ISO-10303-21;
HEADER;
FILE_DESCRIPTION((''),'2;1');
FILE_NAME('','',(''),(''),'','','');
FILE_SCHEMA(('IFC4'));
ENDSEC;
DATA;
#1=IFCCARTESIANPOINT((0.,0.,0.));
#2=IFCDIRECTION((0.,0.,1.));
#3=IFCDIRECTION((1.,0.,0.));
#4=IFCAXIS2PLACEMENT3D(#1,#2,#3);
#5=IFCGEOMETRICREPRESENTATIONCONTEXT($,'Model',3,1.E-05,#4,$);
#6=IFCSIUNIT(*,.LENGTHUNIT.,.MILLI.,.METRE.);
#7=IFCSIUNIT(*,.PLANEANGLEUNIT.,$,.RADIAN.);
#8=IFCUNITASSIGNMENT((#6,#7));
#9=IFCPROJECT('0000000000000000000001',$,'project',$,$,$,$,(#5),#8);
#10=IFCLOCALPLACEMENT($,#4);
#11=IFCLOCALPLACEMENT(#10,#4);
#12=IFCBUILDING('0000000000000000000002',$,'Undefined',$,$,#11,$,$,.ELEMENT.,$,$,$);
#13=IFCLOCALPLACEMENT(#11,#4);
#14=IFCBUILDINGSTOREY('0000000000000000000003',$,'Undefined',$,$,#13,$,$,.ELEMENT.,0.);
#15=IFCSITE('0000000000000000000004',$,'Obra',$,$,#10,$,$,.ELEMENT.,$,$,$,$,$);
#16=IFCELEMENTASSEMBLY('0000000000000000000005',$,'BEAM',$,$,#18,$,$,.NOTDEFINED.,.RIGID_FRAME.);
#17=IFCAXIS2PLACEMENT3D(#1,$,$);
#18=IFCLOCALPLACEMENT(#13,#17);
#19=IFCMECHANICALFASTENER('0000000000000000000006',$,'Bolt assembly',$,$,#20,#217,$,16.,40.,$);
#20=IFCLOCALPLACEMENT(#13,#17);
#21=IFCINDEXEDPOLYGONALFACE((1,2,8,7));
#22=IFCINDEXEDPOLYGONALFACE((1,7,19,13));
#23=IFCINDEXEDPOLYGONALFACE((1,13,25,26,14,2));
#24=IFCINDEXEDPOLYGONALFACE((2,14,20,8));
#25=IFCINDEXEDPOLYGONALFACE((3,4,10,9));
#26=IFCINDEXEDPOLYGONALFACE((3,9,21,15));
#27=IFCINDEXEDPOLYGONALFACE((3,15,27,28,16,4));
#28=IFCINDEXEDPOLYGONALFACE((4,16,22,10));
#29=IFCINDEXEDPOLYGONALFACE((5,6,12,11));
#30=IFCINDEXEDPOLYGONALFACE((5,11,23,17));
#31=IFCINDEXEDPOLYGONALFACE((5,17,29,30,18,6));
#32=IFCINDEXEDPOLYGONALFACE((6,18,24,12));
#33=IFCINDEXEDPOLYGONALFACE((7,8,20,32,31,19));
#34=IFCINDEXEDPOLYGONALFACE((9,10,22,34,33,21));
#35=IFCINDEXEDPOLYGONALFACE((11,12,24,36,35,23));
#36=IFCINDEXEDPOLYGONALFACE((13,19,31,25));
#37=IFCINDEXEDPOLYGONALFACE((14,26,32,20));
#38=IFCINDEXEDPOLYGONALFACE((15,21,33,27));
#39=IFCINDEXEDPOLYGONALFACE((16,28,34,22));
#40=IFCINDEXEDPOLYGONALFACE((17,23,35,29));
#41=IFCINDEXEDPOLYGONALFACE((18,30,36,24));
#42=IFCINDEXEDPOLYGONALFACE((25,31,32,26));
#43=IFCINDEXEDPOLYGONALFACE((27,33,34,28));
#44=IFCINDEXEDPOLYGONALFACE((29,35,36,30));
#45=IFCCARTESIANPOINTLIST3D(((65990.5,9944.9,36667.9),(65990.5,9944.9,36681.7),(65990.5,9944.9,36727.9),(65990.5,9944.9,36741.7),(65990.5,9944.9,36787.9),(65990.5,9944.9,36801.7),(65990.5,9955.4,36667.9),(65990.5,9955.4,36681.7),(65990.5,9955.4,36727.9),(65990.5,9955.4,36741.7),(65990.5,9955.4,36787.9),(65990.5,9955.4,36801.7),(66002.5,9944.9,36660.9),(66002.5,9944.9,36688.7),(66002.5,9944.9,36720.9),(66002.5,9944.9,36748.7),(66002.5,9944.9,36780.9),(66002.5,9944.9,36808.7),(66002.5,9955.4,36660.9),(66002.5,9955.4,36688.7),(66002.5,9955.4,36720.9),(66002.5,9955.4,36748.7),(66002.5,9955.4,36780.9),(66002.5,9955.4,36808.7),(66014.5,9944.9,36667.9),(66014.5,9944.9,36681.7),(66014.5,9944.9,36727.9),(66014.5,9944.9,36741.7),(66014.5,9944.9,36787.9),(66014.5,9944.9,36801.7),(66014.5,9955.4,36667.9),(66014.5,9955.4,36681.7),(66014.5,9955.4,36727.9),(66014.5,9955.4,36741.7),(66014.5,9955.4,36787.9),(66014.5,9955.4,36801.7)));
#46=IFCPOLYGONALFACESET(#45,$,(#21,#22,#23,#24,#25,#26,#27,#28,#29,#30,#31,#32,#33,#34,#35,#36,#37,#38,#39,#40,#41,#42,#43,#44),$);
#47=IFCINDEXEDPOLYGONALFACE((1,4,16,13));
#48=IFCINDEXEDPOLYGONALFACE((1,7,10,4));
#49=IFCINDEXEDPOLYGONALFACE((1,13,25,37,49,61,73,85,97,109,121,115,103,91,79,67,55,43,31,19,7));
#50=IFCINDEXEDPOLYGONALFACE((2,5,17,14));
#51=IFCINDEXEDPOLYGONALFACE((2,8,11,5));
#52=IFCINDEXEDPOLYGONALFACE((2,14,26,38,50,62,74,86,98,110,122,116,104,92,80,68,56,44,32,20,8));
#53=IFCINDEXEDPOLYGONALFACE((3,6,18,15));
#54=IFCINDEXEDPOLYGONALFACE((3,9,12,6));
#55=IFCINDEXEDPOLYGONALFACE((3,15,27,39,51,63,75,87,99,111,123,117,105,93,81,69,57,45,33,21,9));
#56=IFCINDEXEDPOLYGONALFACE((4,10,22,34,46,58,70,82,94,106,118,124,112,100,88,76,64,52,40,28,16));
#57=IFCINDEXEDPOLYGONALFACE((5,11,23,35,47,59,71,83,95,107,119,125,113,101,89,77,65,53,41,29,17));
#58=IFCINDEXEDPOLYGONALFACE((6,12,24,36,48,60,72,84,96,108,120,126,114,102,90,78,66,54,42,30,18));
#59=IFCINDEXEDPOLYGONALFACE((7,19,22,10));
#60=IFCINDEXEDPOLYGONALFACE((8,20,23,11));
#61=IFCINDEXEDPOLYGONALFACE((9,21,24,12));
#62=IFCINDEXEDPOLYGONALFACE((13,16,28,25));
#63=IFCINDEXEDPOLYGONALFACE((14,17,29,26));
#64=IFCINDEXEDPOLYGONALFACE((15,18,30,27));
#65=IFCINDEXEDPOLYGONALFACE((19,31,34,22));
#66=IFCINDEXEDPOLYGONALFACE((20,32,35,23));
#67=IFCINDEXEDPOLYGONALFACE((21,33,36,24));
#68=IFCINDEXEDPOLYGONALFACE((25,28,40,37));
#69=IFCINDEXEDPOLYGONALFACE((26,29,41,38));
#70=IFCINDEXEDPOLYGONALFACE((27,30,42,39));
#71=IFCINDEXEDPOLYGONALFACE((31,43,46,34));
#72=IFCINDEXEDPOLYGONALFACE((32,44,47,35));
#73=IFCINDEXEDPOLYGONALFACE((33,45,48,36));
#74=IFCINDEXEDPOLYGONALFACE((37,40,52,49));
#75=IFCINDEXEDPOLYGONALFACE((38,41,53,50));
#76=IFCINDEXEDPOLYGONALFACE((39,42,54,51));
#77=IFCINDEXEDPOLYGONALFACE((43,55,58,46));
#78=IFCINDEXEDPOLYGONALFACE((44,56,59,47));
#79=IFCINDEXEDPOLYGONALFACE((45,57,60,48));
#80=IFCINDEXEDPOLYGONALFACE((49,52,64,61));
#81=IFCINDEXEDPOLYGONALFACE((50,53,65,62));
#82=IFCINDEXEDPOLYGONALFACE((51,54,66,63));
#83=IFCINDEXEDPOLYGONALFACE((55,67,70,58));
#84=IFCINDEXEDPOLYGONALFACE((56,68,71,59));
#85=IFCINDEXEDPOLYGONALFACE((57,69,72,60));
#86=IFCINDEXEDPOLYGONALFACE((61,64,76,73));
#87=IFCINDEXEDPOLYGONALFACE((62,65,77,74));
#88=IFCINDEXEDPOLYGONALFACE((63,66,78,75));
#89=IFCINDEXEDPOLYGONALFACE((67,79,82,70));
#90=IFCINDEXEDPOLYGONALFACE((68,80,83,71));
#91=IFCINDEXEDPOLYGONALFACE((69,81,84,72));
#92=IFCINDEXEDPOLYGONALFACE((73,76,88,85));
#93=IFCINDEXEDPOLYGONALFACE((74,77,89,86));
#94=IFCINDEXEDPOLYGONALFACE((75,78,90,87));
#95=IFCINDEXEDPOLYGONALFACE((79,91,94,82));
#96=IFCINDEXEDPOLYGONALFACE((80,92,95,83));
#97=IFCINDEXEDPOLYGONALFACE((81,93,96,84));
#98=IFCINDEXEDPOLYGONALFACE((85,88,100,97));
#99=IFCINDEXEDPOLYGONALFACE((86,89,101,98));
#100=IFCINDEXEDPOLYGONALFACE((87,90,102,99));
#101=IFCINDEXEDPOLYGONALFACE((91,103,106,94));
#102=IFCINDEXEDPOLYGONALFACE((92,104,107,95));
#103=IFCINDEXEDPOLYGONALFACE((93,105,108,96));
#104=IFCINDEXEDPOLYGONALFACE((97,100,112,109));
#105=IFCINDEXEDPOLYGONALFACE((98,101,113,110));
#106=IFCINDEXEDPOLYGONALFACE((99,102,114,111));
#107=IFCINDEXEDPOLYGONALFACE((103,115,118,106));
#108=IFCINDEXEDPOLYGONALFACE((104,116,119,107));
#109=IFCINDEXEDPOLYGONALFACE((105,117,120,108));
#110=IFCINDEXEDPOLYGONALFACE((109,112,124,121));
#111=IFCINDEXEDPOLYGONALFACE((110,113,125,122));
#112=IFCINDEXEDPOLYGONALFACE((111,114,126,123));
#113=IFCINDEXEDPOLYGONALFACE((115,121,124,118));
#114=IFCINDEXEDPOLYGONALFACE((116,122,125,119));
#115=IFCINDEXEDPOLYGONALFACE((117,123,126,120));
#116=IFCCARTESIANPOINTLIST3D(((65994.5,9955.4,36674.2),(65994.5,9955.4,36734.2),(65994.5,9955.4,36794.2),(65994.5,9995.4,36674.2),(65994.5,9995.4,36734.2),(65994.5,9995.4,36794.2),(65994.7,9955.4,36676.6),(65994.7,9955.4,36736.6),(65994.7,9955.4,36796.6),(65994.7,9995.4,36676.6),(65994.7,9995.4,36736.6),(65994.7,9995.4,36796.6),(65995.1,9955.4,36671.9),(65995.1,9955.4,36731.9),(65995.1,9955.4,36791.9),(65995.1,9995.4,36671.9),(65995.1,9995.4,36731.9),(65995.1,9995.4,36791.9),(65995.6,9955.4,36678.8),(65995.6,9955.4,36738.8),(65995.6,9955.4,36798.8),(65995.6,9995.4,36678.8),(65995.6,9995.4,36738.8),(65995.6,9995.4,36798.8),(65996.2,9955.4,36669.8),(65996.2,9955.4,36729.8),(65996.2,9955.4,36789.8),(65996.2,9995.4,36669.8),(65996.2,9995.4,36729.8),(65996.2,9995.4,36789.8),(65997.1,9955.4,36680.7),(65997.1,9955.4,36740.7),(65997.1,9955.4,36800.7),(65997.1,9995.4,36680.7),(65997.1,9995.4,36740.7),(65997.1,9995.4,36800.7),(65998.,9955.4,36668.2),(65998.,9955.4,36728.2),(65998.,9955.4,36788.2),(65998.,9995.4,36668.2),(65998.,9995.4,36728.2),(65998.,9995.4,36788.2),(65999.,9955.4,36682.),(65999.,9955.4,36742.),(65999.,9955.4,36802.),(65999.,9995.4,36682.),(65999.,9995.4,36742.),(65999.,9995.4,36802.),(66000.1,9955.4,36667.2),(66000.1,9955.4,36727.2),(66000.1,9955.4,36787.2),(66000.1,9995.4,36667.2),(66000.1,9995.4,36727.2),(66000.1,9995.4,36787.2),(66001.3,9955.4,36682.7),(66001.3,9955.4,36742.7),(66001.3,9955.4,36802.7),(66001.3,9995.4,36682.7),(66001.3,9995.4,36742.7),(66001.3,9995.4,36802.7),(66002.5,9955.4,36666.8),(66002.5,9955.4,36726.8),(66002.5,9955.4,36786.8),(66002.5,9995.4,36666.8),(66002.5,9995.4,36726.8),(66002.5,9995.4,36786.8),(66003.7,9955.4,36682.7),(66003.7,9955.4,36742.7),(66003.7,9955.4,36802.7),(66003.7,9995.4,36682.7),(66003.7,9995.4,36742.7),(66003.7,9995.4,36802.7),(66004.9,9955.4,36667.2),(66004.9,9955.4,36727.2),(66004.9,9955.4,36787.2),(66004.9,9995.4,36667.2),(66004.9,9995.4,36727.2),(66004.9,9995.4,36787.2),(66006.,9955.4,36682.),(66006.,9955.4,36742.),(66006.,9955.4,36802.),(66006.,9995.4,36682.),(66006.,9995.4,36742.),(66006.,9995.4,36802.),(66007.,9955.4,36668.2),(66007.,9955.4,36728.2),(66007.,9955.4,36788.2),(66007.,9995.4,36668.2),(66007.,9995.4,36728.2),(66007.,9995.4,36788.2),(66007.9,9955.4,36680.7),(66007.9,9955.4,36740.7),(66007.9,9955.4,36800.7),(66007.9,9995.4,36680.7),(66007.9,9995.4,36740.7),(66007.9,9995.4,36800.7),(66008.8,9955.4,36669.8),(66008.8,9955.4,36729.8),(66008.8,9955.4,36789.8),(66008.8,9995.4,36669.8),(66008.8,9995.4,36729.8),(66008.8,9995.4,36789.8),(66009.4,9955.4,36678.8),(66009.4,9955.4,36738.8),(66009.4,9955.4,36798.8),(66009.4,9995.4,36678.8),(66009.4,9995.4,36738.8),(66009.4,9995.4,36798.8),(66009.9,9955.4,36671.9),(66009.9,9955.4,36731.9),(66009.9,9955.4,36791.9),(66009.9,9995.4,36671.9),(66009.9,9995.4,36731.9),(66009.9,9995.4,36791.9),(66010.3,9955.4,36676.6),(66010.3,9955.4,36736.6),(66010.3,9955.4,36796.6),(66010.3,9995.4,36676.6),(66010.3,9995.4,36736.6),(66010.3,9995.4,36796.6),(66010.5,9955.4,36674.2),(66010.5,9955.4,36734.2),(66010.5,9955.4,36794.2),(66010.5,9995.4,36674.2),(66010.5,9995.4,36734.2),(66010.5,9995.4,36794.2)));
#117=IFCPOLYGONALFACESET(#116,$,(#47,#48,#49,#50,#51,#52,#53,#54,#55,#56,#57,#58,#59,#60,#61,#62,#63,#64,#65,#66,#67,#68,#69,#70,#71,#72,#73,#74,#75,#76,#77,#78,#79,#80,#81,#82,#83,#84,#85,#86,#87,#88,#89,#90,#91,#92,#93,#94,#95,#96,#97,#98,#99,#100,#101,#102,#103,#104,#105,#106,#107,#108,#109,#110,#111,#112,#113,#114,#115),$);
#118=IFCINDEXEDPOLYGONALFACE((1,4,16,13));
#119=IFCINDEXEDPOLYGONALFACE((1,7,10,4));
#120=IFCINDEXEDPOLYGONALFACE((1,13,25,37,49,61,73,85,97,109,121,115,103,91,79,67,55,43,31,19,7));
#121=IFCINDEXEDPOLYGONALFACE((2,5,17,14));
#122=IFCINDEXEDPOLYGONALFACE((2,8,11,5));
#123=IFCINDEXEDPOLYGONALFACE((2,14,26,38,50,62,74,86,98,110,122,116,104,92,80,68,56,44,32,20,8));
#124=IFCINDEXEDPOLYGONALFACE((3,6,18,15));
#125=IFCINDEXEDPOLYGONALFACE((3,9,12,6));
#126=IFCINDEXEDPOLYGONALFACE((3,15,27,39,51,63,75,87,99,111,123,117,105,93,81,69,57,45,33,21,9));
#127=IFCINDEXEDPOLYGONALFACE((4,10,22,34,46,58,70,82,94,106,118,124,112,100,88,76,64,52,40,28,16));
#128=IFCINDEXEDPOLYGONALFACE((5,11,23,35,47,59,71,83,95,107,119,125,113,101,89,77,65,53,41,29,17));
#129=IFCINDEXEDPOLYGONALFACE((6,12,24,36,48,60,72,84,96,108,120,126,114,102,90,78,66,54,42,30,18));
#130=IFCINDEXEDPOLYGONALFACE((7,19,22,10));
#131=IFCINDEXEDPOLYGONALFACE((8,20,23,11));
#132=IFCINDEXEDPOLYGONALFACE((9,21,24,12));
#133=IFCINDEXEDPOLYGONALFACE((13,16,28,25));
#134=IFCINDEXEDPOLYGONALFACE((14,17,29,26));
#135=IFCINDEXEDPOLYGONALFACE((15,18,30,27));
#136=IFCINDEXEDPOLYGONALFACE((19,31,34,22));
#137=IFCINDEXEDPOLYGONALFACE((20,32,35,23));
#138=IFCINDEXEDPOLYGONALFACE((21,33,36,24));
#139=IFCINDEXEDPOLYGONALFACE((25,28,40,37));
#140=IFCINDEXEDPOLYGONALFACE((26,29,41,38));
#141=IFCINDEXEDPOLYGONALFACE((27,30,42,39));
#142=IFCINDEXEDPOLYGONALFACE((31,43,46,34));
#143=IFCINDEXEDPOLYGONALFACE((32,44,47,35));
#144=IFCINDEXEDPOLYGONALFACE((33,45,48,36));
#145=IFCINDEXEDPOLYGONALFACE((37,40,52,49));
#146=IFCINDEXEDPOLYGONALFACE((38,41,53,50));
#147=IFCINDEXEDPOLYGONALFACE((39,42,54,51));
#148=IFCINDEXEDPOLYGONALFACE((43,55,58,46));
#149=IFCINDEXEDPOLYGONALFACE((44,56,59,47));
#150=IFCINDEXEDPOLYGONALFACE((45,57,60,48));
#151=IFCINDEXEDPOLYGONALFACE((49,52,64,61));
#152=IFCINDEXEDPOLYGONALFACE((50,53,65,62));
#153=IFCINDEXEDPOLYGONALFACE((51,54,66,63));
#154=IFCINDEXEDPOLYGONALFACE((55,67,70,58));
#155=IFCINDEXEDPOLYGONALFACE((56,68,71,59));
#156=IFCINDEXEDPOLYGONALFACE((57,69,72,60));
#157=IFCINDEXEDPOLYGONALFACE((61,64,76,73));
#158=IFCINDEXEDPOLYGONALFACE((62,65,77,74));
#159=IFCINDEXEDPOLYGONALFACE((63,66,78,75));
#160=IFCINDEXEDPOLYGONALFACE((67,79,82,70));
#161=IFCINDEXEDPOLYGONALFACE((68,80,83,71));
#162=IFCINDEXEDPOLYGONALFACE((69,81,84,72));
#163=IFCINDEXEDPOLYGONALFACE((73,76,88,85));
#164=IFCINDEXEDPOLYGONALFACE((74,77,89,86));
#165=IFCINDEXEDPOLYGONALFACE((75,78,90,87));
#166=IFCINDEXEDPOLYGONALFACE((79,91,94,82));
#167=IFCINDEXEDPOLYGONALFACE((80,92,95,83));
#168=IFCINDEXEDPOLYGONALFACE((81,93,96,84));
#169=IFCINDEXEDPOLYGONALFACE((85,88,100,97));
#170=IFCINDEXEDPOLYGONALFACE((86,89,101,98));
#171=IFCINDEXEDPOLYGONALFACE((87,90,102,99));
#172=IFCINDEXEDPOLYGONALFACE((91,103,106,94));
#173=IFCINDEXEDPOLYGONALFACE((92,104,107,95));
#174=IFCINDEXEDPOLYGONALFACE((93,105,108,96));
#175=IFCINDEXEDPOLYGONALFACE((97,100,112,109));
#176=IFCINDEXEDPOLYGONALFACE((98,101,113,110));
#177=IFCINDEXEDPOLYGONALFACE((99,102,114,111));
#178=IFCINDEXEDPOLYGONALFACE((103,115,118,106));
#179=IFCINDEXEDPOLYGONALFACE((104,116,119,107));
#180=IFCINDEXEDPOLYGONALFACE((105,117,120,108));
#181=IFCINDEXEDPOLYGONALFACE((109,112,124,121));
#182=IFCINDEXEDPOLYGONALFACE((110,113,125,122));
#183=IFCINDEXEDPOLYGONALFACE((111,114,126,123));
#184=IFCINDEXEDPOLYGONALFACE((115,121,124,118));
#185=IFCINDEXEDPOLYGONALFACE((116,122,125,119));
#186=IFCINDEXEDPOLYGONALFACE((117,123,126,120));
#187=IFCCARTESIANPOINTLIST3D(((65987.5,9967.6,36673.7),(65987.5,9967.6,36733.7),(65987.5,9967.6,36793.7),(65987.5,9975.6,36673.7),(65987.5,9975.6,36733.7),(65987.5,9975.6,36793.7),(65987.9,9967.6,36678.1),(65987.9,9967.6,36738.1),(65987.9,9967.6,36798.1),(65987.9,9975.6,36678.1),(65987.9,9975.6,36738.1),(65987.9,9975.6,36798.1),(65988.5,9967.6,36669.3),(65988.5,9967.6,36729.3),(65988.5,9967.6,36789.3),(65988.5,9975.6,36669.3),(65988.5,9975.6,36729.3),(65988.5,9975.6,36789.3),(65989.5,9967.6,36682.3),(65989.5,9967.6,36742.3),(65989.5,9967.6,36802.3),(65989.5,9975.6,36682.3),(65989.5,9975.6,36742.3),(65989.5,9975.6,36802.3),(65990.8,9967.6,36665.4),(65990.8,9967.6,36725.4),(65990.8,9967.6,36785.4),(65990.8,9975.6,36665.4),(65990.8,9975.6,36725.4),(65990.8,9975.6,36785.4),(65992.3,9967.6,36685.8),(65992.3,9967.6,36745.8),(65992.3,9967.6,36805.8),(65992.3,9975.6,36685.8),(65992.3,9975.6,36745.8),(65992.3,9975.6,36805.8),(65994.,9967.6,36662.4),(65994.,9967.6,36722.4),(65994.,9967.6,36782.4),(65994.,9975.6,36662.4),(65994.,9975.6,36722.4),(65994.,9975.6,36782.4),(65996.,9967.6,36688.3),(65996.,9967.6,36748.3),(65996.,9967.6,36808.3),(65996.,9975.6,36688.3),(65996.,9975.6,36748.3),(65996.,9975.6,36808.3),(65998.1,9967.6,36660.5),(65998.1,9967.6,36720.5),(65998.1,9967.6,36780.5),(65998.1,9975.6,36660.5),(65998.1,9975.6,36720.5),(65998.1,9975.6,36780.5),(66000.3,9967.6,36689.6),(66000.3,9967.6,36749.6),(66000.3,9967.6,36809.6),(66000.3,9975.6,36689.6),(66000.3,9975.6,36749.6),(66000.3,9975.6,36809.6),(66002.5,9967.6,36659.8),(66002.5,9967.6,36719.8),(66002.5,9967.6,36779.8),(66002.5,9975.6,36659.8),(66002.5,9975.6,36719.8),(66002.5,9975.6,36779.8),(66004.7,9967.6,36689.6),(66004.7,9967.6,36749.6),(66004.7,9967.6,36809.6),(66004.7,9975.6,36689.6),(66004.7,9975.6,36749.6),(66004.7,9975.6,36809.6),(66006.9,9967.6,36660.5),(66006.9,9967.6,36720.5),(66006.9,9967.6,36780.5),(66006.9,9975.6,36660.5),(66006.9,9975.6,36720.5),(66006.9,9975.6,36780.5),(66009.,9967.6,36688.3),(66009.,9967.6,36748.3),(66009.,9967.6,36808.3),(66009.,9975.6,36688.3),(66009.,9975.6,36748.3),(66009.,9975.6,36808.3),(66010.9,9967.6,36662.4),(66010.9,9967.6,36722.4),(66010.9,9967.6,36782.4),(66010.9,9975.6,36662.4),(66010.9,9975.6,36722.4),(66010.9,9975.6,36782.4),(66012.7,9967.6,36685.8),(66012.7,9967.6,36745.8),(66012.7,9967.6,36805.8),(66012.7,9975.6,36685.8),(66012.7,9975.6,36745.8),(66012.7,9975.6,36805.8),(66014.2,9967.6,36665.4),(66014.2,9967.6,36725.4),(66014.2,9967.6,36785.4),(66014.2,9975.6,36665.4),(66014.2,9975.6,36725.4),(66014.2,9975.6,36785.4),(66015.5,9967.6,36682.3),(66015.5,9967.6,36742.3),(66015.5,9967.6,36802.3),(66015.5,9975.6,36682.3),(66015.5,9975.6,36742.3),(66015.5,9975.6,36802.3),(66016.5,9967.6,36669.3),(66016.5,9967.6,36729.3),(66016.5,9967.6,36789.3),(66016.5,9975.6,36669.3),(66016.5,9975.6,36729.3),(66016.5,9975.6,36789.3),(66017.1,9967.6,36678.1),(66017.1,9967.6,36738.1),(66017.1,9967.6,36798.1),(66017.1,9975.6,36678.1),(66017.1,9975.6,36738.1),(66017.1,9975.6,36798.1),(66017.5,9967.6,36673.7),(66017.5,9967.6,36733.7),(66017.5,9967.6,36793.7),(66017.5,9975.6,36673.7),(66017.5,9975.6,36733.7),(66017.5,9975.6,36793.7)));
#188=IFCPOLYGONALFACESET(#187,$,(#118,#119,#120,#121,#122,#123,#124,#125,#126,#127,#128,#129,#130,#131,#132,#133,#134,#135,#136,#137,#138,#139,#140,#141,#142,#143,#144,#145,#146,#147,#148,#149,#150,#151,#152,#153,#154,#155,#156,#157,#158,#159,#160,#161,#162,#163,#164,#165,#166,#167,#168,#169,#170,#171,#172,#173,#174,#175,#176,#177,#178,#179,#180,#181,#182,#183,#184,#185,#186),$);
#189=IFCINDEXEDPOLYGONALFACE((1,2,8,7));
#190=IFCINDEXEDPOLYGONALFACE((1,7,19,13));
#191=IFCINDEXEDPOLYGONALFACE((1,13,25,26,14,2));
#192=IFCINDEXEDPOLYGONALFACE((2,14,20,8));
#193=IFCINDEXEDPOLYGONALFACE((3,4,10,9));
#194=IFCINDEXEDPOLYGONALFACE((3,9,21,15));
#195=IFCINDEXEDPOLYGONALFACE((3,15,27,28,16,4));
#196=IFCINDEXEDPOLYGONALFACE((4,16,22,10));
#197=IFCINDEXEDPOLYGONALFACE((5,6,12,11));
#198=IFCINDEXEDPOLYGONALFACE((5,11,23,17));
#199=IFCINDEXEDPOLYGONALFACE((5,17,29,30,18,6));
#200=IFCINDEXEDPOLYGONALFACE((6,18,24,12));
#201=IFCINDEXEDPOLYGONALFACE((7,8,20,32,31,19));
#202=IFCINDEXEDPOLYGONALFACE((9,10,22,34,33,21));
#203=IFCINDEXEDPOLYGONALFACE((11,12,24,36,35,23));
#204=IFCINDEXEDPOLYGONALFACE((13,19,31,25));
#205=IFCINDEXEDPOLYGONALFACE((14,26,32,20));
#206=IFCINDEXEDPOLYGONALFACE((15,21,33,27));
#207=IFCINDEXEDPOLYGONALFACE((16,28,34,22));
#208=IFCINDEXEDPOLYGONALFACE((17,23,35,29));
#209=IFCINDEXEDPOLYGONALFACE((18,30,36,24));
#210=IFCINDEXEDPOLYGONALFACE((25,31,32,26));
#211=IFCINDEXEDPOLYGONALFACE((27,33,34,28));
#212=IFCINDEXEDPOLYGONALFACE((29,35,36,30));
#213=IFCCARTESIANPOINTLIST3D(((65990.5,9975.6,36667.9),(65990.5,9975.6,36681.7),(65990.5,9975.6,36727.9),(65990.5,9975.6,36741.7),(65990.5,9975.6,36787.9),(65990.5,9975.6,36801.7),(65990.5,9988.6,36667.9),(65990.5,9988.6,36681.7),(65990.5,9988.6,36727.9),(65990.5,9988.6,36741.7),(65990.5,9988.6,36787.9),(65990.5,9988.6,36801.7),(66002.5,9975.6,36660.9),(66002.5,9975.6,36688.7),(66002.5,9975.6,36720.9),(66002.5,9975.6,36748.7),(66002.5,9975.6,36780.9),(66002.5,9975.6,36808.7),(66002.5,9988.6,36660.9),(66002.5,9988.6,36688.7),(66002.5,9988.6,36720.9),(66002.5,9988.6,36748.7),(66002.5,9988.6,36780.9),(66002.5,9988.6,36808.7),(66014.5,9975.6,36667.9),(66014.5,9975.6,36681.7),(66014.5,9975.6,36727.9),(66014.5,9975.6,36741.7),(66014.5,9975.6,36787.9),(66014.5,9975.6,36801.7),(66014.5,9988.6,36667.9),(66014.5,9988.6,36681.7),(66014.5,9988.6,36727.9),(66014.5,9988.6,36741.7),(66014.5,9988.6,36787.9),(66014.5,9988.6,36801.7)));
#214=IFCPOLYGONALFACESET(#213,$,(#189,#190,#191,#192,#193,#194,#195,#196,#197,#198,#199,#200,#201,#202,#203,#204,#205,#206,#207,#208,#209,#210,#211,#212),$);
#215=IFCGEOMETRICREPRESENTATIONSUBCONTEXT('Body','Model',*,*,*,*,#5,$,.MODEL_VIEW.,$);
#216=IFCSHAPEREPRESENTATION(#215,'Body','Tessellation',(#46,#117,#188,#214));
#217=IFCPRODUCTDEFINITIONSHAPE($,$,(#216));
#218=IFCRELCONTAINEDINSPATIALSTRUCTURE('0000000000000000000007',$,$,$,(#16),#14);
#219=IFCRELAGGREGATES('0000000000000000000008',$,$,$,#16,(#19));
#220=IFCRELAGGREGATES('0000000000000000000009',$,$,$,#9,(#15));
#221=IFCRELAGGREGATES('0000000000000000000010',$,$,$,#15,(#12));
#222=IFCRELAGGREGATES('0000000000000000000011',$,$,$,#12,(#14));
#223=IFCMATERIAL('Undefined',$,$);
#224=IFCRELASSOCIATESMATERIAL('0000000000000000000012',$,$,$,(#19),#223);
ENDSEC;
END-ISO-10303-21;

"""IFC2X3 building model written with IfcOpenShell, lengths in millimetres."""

from ifc_helpers import new_model, si_unit, frame, origin_with_axes, origin_2d_with_axis, place, context, subcontext, project, spatial, polyline, circle, outline, extrude, source, transform, mapped, material, element, aggregate, save


model = new_model("IFC2X3")

# Units and contexts
model_context = context("Model", 3, precision=1e-05, world=origin_with_axes())
body_context = subcontext(model_context, "Body", "Model", "MODEL_VIEW")
ifc_project = project(units=[si_unit("LENGTHUNIT", "METRE", prefix="MILLI"), si_unit("PLANEANGLEUNIT", "RADIAN")], contexts=[model_context])

# Site, building, storey
site_placement = place(None, origin_with_axes())
site = spatial("IfcSite", under=ifc_project, at=site_placement, Name="Obra", CompositionType="ELEMENT")
building_placement = place(site_placement, origin_with_axes())
building = spatial("IfcBuilding", under=site, at=building_placement, Name="Undefined", CompositionType="ELEMENT")
storey_placement = place(building_placement, origin_with_axes())
storey = spatial("IfcBuildingStorey", under=building, at=storey_placement, Name="Undefined", CompositionType="ELEMENT", Elevation=0.0)

# Element assembly, mechanical fastener
ifc_material_1 = material(Name="Undefined")
assembly_1_placement = place(storey_placement, origin_with_axes())
assembly_1 = element("IfcElementAssembly", 1, at=assembly_1_placement, inside=storey, Name="BEAM", AssemblyPlace="NOTDEFINED", PredefinedType="RIGID_FRAME")
shared_shape_1 = source(origin_with_axes(), body_context, "Body", "SweptSolid", [
    extrude(outline(polyline([(13.9, 0.0), (6.9, 12.0), (-6.9, 12.0), (-13.9, 0.0), (-6.9, -12.0), (6.9, -12.0), (13.9, 0.0)])), frame((0.0, -13.7, 0.0), z_axis=(0.0, 1.0, 0.0), x_axis=(1.0, 0.0, 0.0)), (0.0, 0.0, 1.0), 10.6),
    extrude(circle(Radius=8.0, at=origin_2d_with_axis()), frame((0.0, -3.1, 0.0), z_axis=(0.0, 1.0, 0.0), x_axis=(1.0, 0.0, 0.0)), (0.0, 0.0, 1.0), 40.0),
    extrude(circle(Radius=15.0, at=origin_2d_with_axis()), frame((0.0, 9.1, 0.0), z_axis=(0.0, 1.0, 0.0), x_axis=(1.0, 0.0, 0.0)), (0.0, 0.0, 1.0), 8.0),
    extrude(outline(polyline([(13.9, 0.0), (6.9, 12.0), (-6.9, 12.0), (-13.9, 0.0), (-6.9, -12.0), (6.9, -12.0), (13.9, 0.0)])), frame((0.0, 17.1, 0.0), z_axis=(0.0, 1.0, 0.0), x_axis=(1.0, 0.0, 0.0)), (0.0, 0.0, 1.0), 13.0),
])
mechanical_fastener_1_placement = place(assembly_1_placement, frame((65952.5, 9958.5, 36829.8), z_axis=(1.0, 0.0, 0.0), x_axis=(0.0, 0.0, -1.0)))
mechanical_fastener_1 = element("IfcMechanicalFastener", 2, at=mechanical_fastener_1_placement, material=ifc_material_1, Name="Bolt assembly", NominalDiameter=16.0, NominalLength=40.0, context=body_context, shape_type="MappedRepresentation", body=[
    mapped(shared_shape_1, transform((35.0, 0.0, 50.0))),
    mapped(shared_shape_1, transform((95.0, 0.0, 50.0))),
    mapped(shared_shape_1, transform((155.0, 0.0, 50.0))),
])
aggregate(assembly_1, [mechanical_fastener_1])

save(model, "model.ifc")
